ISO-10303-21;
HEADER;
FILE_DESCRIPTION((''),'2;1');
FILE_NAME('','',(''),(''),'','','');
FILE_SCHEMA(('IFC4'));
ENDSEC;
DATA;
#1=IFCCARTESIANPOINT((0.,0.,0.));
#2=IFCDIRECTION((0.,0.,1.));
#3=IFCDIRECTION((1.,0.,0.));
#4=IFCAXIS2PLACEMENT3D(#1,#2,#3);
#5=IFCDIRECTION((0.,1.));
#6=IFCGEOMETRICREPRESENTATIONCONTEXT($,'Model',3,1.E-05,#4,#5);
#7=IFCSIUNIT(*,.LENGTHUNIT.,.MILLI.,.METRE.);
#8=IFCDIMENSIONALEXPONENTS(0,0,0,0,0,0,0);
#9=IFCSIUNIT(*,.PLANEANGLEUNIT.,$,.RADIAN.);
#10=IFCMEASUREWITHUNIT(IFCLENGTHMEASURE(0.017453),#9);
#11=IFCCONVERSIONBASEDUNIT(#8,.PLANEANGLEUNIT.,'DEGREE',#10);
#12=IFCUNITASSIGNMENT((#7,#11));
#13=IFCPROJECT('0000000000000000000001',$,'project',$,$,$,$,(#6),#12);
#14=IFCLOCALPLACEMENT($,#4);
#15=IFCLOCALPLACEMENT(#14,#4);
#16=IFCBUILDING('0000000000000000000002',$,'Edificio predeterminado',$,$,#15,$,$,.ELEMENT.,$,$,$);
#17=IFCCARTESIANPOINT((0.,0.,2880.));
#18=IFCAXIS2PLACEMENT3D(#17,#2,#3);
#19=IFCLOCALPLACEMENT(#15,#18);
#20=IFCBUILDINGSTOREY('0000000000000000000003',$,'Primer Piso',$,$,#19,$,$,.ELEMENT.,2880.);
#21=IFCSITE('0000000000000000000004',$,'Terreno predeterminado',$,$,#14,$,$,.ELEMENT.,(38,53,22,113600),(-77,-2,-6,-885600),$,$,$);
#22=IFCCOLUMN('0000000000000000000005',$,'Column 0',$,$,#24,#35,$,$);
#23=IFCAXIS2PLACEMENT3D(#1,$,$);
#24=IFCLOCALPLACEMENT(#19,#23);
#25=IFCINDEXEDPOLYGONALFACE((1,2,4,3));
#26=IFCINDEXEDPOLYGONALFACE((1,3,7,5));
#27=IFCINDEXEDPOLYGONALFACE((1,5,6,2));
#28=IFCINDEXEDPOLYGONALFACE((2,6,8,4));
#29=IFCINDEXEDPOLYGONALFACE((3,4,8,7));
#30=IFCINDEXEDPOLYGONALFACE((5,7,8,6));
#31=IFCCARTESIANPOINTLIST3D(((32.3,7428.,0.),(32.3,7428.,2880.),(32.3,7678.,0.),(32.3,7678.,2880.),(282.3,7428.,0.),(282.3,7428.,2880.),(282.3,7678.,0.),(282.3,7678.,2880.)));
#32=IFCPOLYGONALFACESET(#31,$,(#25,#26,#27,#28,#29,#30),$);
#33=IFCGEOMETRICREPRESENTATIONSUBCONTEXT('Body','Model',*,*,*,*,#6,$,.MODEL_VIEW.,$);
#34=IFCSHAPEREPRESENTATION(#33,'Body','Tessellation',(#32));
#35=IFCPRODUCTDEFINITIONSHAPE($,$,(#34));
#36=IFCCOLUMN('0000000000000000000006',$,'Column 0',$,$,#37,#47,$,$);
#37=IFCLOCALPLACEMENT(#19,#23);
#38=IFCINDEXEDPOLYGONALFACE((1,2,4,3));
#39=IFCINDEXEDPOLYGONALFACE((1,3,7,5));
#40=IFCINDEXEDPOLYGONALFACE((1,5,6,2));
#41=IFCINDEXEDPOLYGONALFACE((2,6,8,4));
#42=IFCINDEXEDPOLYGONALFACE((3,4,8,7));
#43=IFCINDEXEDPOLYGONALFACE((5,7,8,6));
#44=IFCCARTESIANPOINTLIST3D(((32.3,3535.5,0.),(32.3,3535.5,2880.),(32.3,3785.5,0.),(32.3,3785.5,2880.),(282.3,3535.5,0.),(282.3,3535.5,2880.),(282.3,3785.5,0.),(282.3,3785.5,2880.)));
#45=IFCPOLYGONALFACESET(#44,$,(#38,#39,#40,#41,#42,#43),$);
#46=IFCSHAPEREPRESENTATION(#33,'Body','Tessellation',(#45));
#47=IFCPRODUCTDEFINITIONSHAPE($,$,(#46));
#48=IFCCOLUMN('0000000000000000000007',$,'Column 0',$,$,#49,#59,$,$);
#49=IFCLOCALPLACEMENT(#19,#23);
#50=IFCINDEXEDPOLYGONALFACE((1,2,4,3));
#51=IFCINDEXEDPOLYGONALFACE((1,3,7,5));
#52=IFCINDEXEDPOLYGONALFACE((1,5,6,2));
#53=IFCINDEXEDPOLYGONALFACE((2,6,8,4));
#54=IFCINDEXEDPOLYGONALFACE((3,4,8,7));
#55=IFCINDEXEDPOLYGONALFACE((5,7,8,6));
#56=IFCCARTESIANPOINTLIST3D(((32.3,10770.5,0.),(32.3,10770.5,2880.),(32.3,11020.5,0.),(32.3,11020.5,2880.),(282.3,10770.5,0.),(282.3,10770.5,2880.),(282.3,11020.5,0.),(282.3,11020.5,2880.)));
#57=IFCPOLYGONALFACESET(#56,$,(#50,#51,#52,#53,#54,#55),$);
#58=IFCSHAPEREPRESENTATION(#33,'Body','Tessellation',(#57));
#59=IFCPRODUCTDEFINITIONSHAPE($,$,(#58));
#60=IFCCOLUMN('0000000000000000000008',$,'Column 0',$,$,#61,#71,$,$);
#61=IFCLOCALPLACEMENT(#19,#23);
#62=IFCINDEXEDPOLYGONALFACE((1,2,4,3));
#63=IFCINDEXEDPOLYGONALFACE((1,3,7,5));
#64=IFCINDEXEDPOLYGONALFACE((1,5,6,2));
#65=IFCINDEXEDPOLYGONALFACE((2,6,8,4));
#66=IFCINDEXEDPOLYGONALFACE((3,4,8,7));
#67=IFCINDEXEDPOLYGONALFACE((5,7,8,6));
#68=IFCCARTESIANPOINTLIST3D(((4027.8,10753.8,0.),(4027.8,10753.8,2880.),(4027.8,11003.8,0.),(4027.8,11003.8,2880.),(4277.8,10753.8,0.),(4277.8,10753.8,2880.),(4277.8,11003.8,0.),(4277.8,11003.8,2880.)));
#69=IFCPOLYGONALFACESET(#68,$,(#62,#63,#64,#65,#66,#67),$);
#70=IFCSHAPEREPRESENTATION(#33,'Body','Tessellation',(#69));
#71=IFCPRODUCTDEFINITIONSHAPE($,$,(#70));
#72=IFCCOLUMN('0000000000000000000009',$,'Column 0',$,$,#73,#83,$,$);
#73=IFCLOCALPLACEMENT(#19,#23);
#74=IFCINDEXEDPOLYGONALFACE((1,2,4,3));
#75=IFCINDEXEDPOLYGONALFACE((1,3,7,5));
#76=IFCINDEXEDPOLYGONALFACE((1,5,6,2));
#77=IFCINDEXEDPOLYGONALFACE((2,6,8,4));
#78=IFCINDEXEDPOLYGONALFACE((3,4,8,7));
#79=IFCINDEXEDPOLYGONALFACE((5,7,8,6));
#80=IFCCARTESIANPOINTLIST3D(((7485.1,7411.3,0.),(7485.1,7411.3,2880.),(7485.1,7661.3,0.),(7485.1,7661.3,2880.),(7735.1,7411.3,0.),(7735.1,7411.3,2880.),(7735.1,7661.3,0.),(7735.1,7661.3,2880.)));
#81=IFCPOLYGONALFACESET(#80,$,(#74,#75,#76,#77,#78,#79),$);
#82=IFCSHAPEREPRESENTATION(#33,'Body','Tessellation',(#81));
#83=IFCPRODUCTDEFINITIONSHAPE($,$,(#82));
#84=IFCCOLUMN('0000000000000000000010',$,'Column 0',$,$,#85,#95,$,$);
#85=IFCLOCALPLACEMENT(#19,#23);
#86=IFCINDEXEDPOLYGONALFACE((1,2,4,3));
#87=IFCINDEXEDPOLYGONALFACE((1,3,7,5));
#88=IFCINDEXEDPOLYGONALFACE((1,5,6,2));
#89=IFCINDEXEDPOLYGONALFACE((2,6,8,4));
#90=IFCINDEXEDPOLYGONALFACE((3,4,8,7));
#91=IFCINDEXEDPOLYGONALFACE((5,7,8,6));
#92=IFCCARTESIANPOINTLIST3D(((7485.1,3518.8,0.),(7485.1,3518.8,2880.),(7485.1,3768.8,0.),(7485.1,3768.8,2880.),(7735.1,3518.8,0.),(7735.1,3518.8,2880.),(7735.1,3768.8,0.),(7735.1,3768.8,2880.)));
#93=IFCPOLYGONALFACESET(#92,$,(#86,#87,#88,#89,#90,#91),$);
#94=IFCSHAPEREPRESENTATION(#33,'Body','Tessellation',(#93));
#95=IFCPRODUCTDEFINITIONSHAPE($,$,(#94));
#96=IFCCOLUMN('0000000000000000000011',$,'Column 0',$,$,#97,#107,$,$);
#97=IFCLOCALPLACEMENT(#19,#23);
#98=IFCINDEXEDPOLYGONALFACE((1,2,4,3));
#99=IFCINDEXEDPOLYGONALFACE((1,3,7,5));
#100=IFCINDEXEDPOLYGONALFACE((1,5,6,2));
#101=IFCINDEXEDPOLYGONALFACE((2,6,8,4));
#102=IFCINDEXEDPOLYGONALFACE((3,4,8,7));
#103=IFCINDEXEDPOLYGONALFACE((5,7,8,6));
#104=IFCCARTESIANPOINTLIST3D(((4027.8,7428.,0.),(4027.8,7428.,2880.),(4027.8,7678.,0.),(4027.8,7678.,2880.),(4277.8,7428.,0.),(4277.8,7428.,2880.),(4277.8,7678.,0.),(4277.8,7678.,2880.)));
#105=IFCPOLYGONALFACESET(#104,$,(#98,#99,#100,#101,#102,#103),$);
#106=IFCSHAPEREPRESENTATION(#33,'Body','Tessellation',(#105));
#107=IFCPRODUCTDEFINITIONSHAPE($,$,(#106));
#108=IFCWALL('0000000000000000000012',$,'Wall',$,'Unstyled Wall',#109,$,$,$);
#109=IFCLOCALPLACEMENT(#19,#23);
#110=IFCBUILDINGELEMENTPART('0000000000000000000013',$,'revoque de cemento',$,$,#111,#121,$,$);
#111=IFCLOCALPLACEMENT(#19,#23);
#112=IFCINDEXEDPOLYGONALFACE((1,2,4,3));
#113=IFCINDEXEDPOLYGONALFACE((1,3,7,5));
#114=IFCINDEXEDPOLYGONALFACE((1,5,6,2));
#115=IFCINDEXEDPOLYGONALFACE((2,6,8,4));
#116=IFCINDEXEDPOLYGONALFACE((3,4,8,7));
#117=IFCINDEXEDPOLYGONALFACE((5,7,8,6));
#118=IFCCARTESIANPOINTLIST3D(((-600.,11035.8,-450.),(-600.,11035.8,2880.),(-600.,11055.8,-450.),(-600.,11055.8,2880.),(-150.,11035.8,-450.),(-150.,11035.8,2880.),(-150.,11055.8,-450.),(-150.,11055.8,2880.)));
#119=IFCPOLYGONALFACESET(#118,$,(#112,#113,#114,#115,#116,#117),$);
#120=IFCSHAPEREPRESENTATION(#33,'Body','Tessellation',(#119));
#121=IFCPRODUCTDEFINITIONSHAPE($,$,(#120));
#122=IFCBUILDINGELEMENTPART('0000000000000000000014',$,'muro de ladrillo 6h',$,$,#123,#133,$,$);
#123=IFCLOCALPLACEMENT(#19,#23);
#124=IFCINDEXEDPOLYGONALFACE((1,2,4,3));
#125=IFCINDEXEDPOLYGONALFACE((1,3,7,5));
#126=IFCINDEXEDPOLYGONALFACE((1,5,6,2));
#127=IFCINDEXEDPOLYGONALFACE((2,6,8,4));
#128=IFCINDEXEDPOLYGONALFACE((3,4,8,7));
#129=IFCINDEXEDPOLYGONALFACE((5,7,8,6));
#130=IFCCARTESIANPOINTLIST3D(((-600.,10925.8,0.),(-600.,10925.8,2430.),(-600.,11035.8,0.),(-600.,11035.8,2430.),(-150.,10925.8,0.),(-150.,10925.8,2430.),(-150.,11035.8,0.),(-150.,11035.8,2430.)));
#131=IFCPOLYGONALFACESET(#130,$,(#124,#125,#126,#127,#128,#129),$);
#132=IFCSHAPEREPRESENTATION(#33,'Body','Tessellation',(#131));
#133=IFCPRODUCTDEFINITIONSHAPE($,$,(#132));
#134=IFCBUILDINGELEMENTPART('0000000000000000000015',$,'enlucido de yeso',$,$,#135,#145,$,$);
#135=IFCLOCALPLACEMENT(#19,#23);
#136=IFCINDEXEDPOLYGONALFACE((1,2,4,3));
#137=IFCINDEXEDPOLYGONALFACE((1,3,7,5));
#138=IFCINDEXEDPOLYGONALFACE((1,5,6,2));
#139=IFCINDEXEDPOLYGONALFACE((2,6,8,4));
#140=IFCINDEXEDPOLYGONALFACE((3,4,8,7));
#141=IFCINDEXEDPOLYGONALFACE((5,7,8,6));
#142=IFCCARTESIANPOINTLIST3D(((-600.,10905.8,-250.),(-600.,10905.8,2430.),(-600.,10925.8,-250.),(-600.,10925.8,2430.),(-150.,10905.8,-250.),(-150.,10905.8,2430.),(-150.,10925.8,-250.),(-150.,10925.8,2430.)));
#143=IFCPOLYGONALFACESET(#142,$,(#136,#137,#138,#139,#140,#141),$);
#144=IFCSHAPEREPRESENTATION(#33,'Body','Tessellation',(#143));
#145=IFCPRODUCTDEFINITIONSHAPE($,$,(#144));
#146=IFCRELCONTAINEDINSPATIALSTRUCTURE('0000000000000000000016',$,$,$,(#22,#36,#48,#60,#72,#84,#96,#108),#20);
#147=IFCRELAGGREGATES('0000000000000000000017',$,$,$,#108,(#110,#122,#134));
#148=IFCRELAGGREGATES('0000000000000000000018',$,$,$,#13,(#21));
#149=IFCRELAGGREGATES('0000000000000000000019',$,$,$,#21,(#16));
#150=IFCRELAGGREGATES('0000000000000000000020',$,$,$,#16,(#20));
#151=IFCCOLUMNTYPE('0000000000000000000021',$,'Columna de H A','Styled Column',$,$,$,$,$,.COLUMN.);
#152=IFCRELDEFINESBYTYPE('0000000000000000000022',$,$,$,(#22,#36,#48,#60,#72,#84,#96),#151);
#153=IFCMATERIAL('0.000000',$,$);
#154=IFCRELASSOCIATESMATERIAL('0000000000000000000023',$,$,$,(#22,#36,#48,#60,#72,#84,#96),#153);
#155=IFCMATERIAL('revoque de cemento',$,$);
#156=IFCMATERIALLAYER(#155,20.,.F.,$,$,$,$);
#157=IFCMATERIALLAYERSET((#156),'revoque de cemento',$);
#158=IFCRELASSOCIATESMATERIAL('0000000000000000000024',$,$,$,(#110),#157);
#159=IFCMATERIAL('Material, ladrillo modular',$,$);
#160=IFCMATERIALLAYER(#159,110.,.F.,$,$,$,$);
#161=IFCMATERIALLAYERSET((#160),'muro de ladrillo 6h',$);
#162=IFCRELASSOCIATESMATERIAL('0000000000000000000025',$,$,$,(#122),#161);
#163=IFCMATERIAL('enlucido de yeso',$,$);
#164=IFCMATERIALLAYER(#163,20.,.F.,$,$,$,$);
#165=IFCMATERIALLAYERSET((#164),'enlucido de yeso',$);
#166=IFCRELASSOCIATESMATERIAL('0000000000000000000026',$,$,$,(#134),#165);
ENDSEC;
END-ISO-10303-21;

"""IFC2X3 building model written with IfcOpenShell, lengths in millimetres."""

from ifc_helpers import new_model, entity, si_unit, converted_unit, direction, frame, origin_with_axes, place, context, subcontext, project, spatial, polyline, outline, extrude, clip, bounded_halfspace, material, layer, layer_set, layer_usage, type_object, element, aggregate, save


model = new_model("IFC2X3")

# Units and contexts
model_context = context("Model", 3, precision=1e-05, world=origin_with_axes(), true_north=direction((0.0, 1.0)))
body_context = subcontext(model_context, "Body", "Model", "MODEL_VIEW")
ifc_project = project(units=[si_unit("LENGTHUNIT", "METRE", prefix="MILLI"), converted_unit("PLANEANGLEUNIT", "DEGREE", entity("IfcLengthMeasure", 0.017453), si_unit("PLANEANGLEUNIT", "RADIAN"), dimensions=[0, 0, 0, 0, 0, 0, 0])], contexts=[model_context])

# Site, building, storey
site_placement = place(None, origin_with_axes())
site = spatial("IfcSite", under=ifc_project, at=site_placement, Name="Terreno predeterminado", CompositionType="ELEMENT", RefLatitude=(38, 53, 22, 113600), RefLongitude=(-77, -2, -6, -885600))
building_placement = place(site_placement, origin_with_axes())
building = spatial("IfcBuilding", under=site, at=building_placement, Name="Edificio predeterminado", CompositionType="ELEMENT")
storey_placement = place(building_placement, frame((0.0, 0.0, 2880.0), z_axis=(0.0, 0.0, 1.0), x_axis=(1.0, 0.0, 0.0)))
storey = spatial("IfcBuildingStorey", under=building, at=storey_placement, Name="Primer Piso", CompositionType="ELEMENT", Elevation=2880.0)

# Columns
ifc_material_1 = material(Name="0.000000")
column_type = type_object("IfcColumnType", Name="Columna de H A", Description="Styled Column", PredefinedType="COLUMN")
for number, where, z_axis, x_axis, name in (
    (1, (157.3, 7553.0, 0.0), (0.0, 0.0, 1.0), (1.0, 0.0, 0.0), "Column 0"),
    (2, (157.3, 3660.5, 0.0), (0.0, 0.0, 1.0), (1.0, 0.0, 0.0), "Column 0"),
    (3, (157.3, 10895.5, 0.0), (0.0, 0.0, 1.0), (1.0, 0.0, 0.0), "Column 0"),
    (4, (4152.8, 10878.8, 0.0), (0.0, 0.0, 1.0), (1.0, 0.0, 0.0), "Column 0"),
    (5, (7610.1, 7536.3, 0.0), (0.0, 0.0, 1.0), (1.0, 0.0, 0.0), "Column 0"),
    (6, (7610.1, 3643.8, 0.0), (0.0, 0.0, 1.0), (1.0, 0.0, 0.0), "Column 0"),
    (7, (4152.8, 7553.0, 0.0), (0.0, 0.0, 1.0), (1.0, 0.0, 0.0), "Column 0"),
):
    element("IfcColumn", number, at=place(storey_placement, frame(where, z_axis=z_axis, x_axis=x_axis)), inside=storey, type_object=column_type, material=ifc_material_1, Name=name, context=body_context, shape_type="SweptSolid", body=[
        extrude(outline(polyline([(-125.0, -125.0), (125.0, -125.0), (125.0, 125.0), (-125.0, 125.0), (-125.0, -125.0)])), origin_with_axes(), (0.0, 0.0, 1.0), 2880.0),
    ])

# Wall, building element parts
wall_1_placement = place(storey_placement, frame((-600.0, 10980.8, 0.0), z_axis=(0.0, 0.0, 1.0), x_axis=(1.0, 0.0, 0.0)))
wall_1 = element("IfcWall", 8, at=wall_1_placement, inside=storey, Name="Wall", ObjectType="Unstyled Wall")
ifc_material_2 = material(Name="revoque de cemento")
ifc_layer_1 = layer(ifc_material_2, 20.0, ventilated=False)
ifc_layer_set_1 = layer_set([ifc_layer_1], Name="revoque de cemento")
ifc_layer_usage_1 = layer_usage(ifc_layer_set_1, "AXIS2", "NEGATIVE", -75.0)
building_element_part_1_placement = place(wall_1_placement, origin_with_axes())
building_element_part_1 = element("IfcBuildingElementPart", 9, at=building_element_part_1_placement, material=ifc_layer_usage_1, Name="revoque de cemento", context=body_context, shape_type="Clipping", body=[
    clip(clip(extrude(outline(polyline([(450.0, 75.0), (450.0, 55.0), (0.0, 55.0), (0.0, 75.0), (450.0, 75.0)])), frame((0.0, 0.0, -450.0), z_axis=(0.0, 0.0, 1.0), x_axis=(1.0, 0.0, 0.0)), (0.0, 0.0, 1.0), 3330.0), bounded_halfspace(frame((0.0, 0.0, -450.0), z_axis=(0.0, 0.0, 1.0), x_axis=(1.0, 0.0, 0.0)), True, origin_with_axes(), polyline([(-150.0, -150.0), (600.0, -150.0), (600.0, 150.0), (-150.0, 150.0), (-150.0, -150.0)]))), bounded_halfspace(frame((0.0, 0.0, 2880.0), z_axis=(0.0, 0.0, 1.0), x_axis=(1.0, 0.0, 0.0)), False, origin_with_axes(), polyline([(-150.0, -150.0), (600.0, -150.0), (600.0, 150.0), (-150.0, 150.0), (-150.0, -150.0)]))),
])
ifc_material_3 = material(Name="Material, ladrillo modular")
ifc_layer_2 = layer(ifc_material_3, 110.0, ventilated=False)
ifc_layer_set_2 = layer_set([ifc_layer_2], Name="muro de ladrillo 6h")
ifc_layer_usage_2 = layer_usage(ifc_layer_set_2, "AXIS2", "NEGATIVE", -55.0)
building_element_part_2_placement = place(wall_1_placement, origin_with_axes())
building_element_part_2 = element("IfcBuildingElementPart", 10, at=building_element_part_2_placement, material=ifc_layer_usage_2, Name="muro de ladrillo 6h", context=body_context, shape_type="Clipping", body=[
    clip(clip(extrude(outline(polyline([(450.0, 55.0), (450.0, -55.0), (0.0, -55.0), (0.0, 55.0), (450.0, 55.0)])), origin_with_axes(), (0.0, 0.0, 1.0), 2430.0), bounded_halfspace(origin_with_axes(), True, origin_with_axes(), polyline([(-150.0, -150.0), (600.0, -150.0), (600.0, 150.0), (-150.0, 150.0), (-150.0, -150.0)]))), bounded_halfspace(frame((0.0, 0.0, 2430.0), z_axis=(0.0, 0.0, 1.0), x_axis=(1.0, 0.0, 0.0)), False, origin_with_axes(), polyline([(-150.0, -150.0), (600.0, -150.0), (600.0, 150.0), (-150.0, 150.0), (-150.0, -150.0)]))),
])
ifc_material_4 = material(Name="enlucido de yeso")
ifc_layer_3 = layer(ifc_material_4, 20.0, ventilated=False)
ifc_layer_set_3 = layer_set([ifc_layer_3], Name="enlucido de yeso")
ifc_layer_usage_3 = layer_usage(ifc_layer_set_3, "AXIS2", "NEGATIVE", 55.0)
building_element_part_3_placement = place(wall_1_placement, origin_with_axes())
building_element_part_3 = element("IfcBuildingElementPart", 11, at=building_element_part_3_placement, material=ifc_layer_usage_3, Name="enlucido de yeso", context=body_context, shape_type="Clipping", body=[
    clip(clip(extrude(outline(polyline([(450.0, -55.0), (450.0, -75.0), (0.0, -75.0), (0.0, -55.0), (450.0, -55.0)])), frame((0.0, 0.0, -250.0), z_axis=(0.0, 0.0, 1.0), x_axis=(1.0, 0.0, 0.0)), (0.0, 0.0, 1.0), 2680.0), bounded_halfspace(frame((0.0, 0.0, -250.0), z_axis=(0.0, 0.0, 1.0), x_axis=(1.0, 0.0, 0.0)), True, origin_with_axes(), polyline([(-150.0, -150.0), (600.0, -150.0), (600.0, 150.0), (-150.0, 150.0), (-150.0, -150.0)]))), bounded_halfspace(frame((0.0, 0.0, 2430.0), z_axis=(0.0, 0.0, 1.0), x_axis=(1.0, 0.0, 0.0)), False, origin_with_axes(), polyline([(-150.0, -150.0), (600.0, -150.0), (600.0, 150.0), (-150.0, 150.0), (-150.0, -150.0)]))),
])
aggregate(wall_1, [building_element_part_1, building_element_part_2, building_element_part_3])

save(model, "model.ifc")
